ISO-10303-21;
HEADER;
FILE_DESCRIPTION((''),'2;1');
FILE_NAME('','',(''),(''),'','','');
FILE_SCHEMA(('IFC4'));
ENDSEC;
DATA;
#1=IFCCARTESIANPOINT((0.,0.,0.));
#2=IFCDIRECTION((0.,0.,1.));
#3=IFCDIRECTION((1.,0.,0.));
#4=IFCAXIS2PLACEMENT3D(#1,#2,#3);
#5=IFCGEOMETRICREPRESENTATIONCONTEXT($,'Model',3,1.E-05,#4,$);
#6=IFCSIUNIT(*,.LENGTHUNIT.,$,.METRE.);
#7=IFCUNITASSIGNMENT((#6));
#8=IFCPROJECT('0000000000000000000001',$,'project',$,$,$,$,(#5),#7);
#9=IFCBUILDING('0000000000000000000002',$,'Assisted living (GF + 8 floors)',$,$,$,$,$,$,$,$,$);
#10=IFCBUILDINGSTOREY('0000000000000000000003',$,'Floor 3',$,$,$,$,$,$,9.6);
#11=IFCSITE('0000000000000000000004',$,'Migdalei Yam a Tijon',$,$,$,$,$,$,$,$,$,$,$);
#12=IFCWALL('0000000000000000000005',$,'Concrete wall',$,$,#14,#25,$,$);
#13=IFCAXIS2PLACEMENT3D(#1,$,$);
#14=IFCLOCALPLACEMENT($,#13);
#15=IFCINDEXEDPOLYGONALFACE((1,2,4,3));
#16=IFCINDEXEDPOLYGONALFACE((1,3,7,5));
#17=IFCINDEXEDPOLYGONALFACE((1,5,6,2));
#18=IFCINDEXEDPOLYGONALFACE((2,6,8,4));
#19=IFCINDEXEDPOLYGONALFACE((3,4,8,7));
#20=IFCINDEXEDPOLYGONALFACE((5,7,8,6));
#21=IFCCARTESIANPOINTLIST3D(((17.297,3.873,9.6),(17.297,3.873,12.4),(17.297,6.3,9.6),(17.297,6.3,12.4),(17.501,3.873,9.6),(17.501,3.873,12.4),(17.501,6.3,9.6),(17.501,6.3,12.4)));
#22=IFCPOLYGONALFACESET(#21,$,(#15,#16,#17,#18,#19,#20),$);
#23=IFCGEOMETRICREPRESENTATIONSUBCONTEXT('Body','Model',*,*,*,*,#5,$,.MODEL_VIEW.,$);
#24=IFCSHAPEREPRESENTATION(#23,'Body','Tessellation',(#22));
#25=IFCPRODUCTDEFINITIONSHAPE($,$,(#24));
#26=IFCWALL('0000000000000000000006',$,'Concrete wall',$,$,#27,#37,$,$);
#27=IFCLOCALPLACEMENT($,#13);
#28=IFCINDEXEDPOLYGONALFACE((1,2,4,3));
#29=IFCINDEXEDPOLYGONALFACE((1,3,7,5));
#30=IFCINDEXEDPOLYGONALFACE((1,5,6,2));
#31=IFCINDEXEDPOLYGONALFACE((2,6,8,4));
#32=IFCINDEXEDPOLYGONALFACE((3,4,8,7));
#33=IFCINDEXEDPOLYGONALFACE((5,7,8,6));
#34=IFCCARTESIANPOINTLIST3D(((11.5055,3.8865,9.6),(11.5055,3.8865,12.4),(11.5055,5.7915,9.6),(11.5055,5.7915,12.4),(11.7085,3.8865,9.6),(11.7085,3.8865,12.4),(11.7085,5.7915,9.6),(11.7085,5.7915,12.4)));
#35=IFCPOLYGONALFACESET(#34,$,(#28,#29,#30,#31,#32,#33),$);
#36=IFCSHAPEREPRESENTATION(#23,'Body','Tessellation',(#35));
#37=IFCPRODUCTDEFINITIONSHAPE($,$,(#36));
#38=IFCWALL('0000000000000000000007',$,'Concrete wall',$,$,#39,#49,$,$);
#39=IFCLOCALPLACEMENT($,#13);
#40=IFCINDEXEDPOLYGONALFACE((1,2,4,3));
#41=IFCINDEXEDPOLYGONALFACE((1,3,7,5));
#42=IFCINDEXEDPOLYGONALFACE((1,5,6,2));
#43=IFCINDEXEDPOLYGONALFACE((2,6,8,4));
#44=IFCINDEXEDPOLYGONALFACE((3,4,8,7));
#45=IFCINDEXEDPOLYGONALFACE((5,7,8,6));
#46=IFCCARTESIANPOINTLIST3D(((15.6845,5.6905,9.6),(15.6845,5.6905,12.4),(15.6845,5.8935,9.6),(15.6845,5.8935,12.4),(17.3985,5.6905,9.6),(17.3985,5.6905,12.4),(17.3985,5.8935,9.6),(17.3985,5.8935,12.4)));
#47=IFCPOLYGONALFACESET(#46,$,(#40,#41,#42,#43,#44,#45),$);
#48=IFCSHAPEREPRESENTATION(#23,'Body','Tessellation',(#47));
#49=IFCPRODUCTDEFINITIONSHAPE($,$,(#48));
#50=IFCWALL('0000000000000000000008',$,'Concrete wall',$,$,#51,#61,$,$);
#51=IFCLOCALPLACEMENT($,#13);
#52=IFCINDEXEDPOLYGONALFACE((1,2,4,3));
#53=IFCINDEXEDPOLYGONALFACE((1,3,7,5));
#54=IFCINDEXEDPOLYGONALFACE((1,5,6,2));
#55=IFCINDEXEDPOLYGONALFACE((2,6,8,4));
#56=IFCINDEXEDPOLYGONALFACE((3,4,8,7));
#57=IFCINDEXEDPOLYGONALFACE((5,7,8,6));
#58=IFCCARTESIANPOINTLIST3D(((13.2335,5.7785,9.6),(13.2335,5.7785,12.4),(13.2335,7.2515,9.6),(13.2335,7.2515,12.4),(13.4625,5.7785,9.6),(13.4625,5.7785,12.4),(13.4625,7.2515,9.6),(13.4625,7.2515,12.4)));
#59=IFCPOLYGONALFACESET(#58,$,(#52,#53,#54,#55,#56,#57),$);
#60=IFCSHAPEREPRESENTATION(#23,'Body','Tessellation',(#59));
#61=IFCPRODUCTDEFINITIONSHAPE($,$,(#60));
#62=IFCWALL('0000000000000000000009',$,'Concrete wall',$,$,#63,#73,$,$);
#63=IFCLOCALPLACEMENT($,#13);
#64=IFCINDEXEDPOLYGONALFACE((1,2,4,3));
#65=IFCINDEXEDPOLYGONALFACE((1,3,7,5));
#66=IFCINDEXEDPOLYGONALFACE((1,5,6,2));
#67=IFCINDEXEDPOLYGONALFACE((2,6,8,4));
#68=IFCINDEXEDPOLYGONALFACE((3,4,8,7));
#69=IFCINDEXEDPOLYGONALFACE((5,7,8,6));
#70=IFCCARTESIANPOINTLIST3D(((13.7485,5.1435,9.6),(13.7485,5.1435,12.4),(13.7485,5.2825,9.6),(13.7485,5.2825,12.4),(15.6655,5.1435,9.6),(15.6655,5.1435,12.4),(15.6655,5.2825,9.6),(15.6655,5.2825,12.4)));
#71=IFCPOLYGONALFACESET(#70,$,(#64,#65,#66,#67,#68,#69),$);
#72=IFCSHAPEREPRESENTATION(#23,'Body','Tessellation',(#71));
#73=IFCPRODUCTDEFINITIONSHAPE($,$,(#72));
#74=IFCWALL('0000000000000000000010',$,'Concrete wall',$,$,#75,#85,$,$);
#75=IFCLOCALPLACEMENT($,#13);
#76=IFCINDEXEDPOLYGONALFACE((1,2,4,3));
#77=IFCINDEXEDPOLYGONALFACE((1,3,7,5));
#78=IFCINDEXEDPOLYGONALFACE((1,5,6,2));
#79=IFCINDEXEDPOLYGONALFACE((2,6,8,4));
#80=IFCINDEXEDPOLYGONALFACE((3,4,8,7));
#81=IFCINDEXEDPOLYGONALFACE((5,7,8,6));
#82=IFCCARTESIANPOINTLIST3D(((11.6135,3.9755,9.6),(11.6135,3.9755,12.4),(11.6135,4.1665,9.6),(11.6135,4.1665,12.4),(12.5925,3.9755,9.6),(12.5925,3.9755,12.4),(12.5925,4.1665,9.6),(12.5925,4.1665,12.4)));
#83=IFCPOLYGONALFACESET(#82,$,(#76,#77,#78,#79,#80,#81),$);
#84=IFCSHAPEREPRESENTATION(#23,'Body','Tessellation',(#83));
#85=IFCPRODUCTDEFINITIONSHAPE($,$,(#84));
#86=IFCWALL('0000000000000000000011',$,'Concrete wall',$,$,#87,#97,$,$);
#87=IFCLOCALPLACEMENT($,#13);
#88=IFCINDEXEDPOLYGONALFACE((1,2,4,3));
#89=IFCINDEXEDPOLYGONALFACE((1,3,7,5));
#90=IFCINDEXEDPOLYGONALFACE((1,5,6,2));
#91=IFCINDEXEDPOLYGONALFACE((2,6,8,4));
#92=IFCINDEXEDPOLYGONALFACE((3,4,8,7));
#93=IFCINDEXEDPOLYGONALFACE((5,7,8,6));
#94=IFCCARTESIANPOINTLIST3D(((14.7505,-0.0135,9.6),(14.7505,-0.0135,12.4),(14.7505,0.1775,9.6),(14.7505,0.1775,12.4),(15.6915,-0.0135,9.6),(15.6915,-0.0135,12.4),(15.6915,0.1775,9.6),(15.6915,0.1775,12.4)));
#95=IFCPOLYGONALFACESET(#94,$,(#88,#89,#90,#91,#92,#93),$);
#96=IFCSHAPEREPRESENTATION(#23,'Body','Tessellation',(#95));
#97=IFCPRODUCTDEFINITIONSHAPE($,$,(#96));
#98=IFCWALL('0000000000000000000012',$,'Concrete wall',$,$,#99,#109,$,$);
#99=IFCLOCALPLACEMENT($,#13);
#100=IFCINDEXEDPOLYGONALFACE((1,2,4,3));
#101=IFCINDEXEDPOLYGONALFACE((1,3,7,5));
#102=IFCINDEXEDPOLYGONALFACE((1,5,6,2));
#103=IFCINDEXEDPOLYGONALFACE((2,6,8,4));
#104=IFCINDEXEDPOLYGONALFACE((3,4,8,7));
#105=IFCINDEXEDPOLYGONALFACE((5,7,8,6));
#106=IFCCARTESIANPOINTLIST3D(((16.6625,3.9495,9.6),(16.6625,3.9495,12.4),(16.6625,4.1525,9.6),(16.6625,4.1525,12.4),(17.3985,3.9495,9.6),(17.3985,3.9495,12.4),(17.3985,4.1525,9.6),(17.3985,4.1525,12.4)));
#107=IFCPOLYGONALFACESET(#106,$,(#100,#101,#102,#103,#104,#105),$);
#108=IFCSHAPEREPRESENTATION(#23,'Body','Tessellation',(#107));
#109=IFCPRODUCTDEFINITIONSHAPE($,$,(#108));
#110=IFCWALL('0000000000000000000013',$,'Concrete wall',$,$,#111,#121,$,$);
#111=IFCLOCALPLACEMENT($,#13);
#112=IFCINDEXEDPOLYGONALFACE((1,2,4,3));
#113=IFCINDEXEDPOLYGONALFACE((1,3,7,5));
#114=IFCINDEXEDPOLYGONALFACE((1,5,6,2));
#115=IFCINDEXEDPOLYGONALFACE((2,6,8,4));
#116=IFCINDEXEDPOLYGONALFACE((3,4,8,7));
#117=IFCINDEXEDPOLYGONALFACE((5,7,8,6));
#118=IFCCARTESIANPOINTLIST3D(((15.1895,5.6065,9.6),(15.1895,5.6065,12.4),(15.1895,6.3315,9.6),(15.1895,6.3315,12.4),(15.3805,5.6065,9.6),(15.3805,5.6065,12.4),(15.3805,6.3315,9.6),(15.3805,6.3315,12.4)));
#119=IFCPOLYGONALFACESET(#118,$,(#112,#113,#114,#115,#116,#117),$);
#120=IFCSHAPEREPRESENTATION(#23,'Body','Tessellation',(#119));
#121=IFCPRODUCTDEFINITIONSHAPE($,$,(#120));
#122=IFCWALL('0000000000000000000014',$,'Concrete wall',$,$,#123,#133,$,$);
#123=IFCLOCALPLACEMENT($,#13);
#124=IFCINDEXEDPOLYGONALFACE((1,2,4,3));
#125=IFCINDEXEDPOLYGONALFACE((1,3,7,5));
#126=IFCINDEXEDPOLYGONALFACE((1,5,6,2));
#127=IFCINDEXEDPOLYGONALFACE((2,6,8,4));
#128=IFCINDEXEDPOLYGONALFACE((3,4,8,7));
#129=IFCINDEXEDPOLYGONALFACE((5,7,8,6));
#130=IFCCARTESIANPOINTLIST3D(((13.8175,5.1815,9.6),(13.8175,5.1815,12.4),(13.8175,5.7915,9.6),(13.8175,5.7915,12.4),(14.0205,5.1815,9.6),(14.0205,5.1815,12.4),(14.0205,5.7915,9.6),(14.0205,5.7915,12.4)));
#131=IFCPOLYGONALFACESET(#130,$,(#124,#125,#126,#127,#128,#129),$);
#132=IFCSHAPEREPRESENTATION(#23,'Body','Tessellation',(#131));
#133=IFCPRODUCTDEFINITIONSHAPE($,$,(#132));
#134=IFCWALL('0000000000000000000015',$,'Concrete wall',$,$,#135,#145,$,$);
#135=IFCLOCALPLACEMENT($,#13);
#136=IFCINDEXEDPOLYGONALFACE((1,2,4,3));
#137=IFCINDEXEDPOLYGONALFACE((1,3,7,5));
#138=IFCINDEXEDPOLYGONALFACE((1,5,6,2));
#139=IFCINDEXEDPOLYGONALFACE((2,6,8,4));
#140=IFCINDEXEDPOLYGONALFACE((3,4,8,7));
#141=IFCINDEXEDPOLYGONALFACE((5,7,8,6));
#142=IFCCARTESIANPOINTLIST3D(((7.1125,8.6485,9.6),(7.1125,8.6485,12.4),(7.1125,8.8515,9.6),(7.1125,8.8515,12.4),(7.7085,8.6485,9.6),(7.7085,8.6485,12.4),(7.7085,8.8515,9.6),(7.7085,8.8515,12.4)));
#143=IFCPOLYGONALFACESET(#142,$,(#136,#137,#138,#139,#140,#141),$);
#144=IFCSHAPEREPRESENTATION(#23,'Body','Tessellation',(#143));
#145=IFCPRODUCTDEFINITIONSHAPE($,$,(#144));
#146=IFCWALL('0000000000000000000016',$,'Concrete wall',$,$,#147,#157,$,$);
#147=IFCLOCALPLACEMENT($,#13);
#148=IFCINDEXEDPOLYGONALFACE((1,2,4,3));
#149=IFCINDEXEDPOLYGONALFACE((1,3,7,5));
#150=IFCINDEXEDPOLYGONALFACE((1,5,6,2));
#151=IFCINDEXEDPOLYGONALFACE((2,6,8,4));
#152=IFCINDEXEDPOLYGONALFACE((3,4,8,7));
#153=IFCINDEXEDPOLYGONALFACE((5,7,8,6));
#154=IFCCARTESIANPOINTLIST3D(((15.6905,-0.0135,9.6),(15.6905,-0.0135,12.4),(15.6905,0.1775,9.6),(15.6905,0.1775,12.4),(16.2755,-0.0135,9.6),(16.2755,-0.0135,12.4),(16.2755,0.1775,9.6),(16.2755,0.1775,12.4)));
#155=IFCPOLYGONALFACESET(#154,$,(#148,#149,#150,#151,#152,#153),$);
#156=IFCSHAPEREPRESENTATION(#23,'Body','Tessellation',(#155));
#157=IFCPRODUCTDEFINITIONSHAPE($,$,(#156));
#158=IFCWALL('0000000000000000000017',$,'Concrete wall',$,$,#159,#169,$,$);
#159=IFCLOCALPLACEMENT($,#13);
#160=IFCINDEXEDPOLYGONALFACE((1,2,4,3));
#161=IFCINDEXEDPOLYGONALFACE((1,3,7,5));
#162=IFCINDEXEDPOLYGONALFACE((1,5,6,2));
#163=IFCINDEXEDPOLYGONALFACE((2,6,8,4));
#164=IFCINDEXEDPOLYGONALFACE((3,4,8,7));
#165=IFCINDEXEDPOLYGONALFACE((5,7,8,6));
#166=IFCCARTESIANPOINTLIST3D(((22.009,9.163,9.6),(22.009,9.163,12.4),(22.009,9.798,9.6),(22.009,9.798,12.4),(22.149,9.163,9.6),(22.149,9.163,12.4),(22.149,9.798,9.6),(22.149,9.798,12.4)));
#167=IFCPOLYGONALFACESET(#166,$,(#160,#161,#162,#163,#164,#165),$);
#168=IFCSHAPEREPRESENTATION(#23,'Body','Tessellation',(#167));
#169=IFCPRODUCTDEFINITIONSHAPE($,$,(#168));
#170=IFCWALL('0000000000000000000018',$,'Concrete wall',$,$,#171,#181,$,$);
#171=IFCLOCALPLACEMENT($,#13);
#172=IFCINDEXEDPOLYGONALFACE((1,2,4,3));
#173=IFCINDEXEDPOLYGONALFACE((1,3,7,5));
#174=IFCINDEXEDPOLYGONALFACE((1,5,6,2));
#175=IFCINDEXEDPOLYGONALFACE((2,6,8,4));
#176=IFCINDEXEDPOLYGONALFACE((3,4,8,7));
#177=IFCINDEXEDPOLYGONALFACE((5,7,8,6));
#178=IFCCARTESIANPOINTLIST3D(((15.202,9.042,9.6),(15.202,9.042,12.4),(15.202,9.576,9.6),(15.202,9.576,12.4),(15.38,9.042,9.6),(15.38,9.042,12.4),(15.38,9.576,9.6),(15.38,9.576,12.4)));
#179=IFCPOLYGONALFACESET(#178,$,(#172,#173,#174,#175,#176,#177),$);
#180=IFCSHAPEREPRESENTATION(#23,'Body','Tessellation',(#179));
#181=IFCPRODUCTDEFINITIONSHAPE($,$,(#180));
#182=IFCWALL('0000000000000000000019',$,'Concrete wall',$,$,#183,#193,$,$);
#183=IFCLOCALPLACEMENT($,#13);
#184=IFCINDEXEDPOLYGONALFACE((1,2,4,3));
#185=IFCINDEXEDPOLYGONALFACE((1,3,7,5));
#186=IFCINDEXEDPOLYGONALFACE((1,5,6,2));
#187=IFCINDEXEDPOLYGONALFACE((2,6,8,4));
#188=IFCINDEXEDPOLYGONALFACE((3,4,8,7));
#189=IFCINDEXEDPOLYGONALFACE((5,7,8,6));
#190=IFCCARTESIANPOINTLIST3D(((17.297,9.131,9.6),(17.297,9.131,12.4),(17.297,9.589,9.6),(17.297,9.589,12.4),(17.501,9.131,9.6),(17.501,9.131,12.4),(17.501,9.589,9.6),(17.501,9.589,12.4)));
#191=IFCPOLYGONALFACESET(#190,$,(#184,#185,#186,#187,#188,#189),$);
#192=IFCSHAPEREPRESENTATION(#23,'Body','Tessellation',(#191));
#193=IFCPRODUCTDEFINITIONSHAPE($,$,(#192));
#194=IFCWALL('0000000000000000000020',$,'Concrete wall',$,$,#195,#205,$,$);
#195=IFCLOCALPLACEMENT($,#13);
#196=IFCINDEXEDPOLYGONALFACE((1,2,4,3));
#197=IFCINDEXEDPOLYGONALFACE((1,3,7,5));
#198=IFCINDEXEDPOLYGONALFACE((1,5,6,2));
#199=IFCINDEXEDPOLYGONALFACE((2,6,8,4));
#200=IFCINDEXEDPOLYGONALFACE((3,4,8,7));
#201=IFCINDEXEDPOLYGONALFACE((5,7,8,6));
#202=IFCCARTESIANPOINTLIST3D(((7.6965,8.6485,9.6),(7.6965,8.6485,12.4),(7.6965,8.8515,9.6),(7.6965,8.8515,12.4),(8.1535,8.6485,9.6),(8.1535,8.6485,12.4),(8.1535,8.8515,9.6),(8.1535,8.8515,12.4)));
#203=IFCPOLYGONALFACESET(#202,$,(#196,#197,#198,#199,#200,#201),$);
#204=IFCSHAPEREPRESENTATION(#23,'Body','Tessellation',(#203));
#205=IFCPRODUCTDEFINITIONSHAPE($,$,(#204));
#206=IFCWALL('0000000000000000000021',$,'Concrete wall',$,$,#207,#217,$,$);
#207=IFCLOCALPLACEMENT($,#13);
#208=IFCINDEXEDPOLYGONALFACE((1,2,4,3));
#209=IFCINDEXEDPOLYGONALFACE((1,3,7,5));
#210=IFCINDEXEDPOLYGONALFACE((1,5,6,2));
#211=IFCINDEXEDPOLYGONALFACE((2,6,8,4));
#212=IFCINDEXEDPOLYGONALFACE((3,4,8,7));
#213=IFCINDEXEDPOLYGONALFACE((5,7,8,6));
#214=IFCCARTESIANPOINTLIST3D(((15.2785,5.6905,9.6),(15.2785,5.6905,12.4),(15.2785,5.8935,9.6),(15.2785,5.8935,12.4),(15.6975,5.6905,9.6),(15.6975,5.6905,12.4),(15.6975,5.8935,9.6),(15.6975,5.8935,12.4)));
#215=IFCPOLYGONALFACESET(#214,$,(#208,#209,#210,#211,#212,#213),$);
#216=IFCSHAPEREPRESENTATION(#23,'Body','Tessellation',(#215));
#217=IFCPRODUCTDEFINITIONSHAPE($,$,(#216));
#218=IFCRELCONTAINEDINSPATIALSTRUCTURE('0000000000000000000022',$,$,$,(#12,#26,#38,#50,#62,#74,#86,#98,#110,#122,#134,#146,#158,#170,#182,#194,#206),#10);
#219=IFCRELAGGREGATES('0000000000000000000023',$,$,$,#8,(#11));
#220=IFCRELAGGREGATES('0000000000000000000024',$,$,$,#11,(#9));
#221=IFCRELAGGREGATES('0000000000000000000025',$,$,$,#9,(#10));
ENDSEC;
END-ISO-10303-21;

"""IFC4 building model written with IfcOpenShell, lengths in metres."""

from ifc_helpers import new_model, si_unit, frame, origin_with_axes, context, subcontext, project, spatial, line, indexed_curve, outline, extrude, element, save


model = new_model("IFC4")

# Units and contexts
model_context = context("Model", 3, precision=1e-05, world=origin_with_axes())
body_context = subcontext(model_context, "Body", "Model", "MODEL_VIEW")
ifc_project = project(units=[si_unit("LENGTHUNIT", "METRE")], contexts=[model_context])

# Site, building, storey
site = spatial("IfcSite", under=ifc_project, Name="Migdalei Yam a Tijon")
building = spatial("IfcBuilding", under=site, Name="Assisted living (GF + 8 floors)")
storey = spatial("IfcBuildingStorey", under=building, Name="Floor 3", Elevation=9.6)

# Walls
element("IfcWall", 1, inside=storey, Name="Concrete wall", context=body_context, shape_type="SweptSolid", body=[
    extrude(outline(indexed_curve([(0.0, 0.0), (0.204, 0.0), (0.204, 2.427), (0.0, 2.427)], segments=[line(1, 2, 3, 4, 1)])), frame((17.297, 3.873, 9.6), z_axis=(0.0, 0.0, 1.0), x_axis=(1.0, 0.0, 0.0)), (0.0, 0.0, 1.0), 2.8),
])
element("IfcWall", 2, inside=storey, Name="Concrete wall", context=body_context, shape_type="SweptSolid", body=[
    extrude(outline(indexed_curve([(0.0, 0.0), (0.203, 0.0), (0.203, 1.905), (0.0, 1.905)], segments=[line(1, 2, 3, 4, 1)])), frame((11.5055, 3.8865, 9.6), z_axis=(0.0, 0.0, 1.0), x_axis=(1.0, 0.0, 0.0)), (0.0, 0.0, 1.0), 2.8),
])
element("IfcWall", 3, inside=storey, Name="Concrete wall", context=body_context, shape_type="SweptSolid", body=[
    extrude(outline(indexed_curve([(0.0, 0.0), (1.714, 0.0), (1.714, 0.203), (0.0, 0.203)], segments=[line(1, 2, 3, 4, 1)])), frame((15.6845, 5.6905, 9.6), z_axis=(0.0, 0.0, 1.0), x_axis=(1.0, 0.0, 0.0)), (0.0, 0.0, 1.0), 2.8),
])
element("IfcWall", 4, inside=storey, Name="Concrete wall", context=body_context, shape_type="SweptSolid", body=[
    extrude(outline(indexed_curve([(0.0, 0.0), (0.229, 0.0), (0.229, 1.473), (0.0, 1.473)], segments=[line(1, 2, 3, 4, 1)])), frame((13.2335, 5.7785, 9.6), z_axis=(0.0, 0.0, 1.0), x_axis=(1.0, 0.0, 0.0)), (0.0, 0.0, 1.0), 2.8),
])
element("IfcWall", 5, inside=storey, Name="Concrete wall", context=body_context, shape_type="SweptSolid", body=[
    extrude(outline(indexed_curve([(0.0, 0.0), (1.917, 0.0), (1.917, 0.139), (0.0, 0.139)], segments=[line(1, 2, 3, 4, 1)])), frame((13.7485, 5.1435, 9.6), z_axis=(0.0, 0.0, 1.0), x_axis=(1.0, 0.0, 0.0)), (0.0, 0.0, 1.0), 2.8),
])
element("IfcWall", 6, inside=storey, Name="Concrete wall", context=body_context, shape_type="SweptSolid", body=[
    extrude(outline(indexed_curve([(0.0, 0.0), (0.979, 0.0), (0.979, 0.191), (0.0, 0.191)], segments=[line(1, 2, 3, 4, 1)])), frame((11.6135, 3.9755, 9.6), z_axis=(0.0, 0.0, 1.0), x_axis=(1.0, 0.0, 0.0)), (0.0, 0.0, 1.0), 2.8),
])
element("IfcWall", 7, inside=storey, Name="Concrete wall", context=body_context, shape_type="SweptSolid", body=[
    extrude(outline(indexed_curve([(0.0, 0.0), (0.941, 0.0), (0.941, 0.191), (0.0, 0.191)], segments=[line(1, 2, 3, 4, 1)])), frame((14.7505, -0.0135, 9.6), z_axis=(0.0, 0.0, 1.0), x_axis=(1.0, 0.0, 0.0)), (0.0, 0.0, 1.0), 2.8),
])
element("IfcWall", 8, inside=storey, Name="Concrete wall", context=body_context, shape_type="SweptSolid", body=[
    extrude(outline(indexed_curve([(0.0, 0.0), (0.736, 0.0), (0.736, 0.203), (0.0, 0.203)], segments=[line(1, 2, 3, 4, 1)])), frame((16.6625, 3.9495, 9.6), z_axis=(0.0, 0.0, 1.0), x_axis=(1.0, 0.0, 0.0)), (0.0, 0.0, 1.0), 2.8),
])
element("IfcWall", 9, inside=storey, Name="Concrete wall", context=body_context, shape_type="SweptSolid", body=[
    extrude(outline(indexed_curve([(0.0, 0.0), (0.191, 0.0), (0.191, 0.725), (0.0, 0.725)], segments=[line(1, 2, 3, 4, 1)])), frame((15.1895, 5.6065, 9.6), z_axis=(0.0, 0.0, 1.0), x_axis=(1.0, 0.0, 0.0)), (0.0, 0.0, 1.0), 2.8),
])
element("IfcWall", 10, inside=storey, Name="Concrete wall", context=body_context, shape_type="SweptSolid", body=[
    extrude(outline(indexed_curve([(0.0, 0.0), (0.203, 0.0), (0.203, 0.61), (0.0, 0.61)], segments=[line(1, 2, 3, 4, 1)])), frame((13.8175, 5.1815, 9.6), z_axis=(0.0, 0.0, 1.0), x_axis=(1.0, 0.0, 0.0)), (0.0, 0.0, 1.0), 2.8),
])
element("IfcWall", 11, inside=storey, Name="Concrete wall", context=body_context, shape_type="SweptSolid", body=[
    extrude(outline(indexed_curve([(0.0, 0.0), (0.596, 0.0), (0.596, 0.203), (0.0, 0.203)], segments=[line(1, 2, 3, 4, 1)])), frame((7.1125, 8.6485, 9.6), z_axis=(0.0, 0.0, 1.0), x_axis=(1.0, 0.0, 0.0)), (0.0, 0.0, 1.0), 2.8),
])
element("IfcWall", 12, inside=storey, Name="Concrete wall", context=body_context, shape_type="SweptSolid", body=[
    extrude(outline(indexed_curve([(0.0, 0.0), (0.585, 0.0), (0.585, 0.191), (0.0, 0.191)], segments=[line(1, 2, 3, 4, 1)])), frame((15.6905, -0.0135, 9.6), z_axis=(0.0, 0.0, 1.0), x_axis=(1.0, 0.0, 0.0)), (0.0, 0.0, 1.0), 2.8),
])
element("IfcWall", 13, inside=storey, Name="Concrete wall", context=body_context, shape_type="SweptSolid", body=[
    extrude(outline(indexed_curve([(0.0, 0.0), (0.14, 0.0), (0.14, 0.635), (0.0, 0.635)], segments=[line(1, 2, 3, 4, 1)])), frame((22.009, 9.163, 9.6), z_axis=(0.0, 0.0, 1.0), x_axis=(1.0, 0.0, 0.0)), (0.0, 0.0, 1.0), 2.8),
])
element("IfcWall", 14, inside=storey, Name="Concrete wall", context=body_context, shape_type="SweptSolid", body=[
    extrude(outline(indexed_curve([(0.0, 0.0), (0.178, 0.0), (0.178, 0.534), (0.0, 0.534)], segments=[line(1, 2, 3, 4, 1)])), frame((15.202, 9.042, 9.6), z_axis=(0.0, 0.0, 1.0), x_axis=(1.0, 0.0, 0.0)), (0.0, 0.0, 1.0), 2.8),
])
element("IfcWall", 15, inside=storey, Name="Concrete wall", context=body_context, shape_type="SweptSolid", body=[
    extrude(outline(indexed_curve([(0.0, 0.0), (0.204, 0.0), (0.204, 0.458), (0.0, 0.458)], segments=[line(1, 2, 3, 4, 1)])), frame((17.297, 9.131, 9.6), z_axis=(0.0, 0.0, 1.0), x_axis=(1.0, 0.0, 0.0)), (0.0, 0.0, 1.0), 2.8),
])
element("IfcWall", 16, inside=storey, Name="Concrete wall", context=body_context, shape_type="SweptSolid", body=[
    extrude(outline(indexed_curve([(0.0, 0.0), (0.457, 0.0), (0.457, 0.203), (0.0, 0.203)], segments=[line(1, 2, 3, 4, 1)])), frame((7.6965, 8.6485, 9.6), z_axis=(0.0, 0.0, 1.0), x_axis=(1.0, 0.0, 0.0)), (0.0, 0.0, 1.0), 2.8),
])
element("IfcWall", 17, inside=storey, Name="Concrete wall", context=body_context, shape_type="SweptSolid", body=[
    extrude(outline(indexed_curve([(0.0, 0.0), (0.419, 0.0), (0.419, 0.203), (0.0, 0.203)], segments=[line(1, 2, 3, 4, 1)])), frame((15.2785, 5.6905, 9.6), z_axis=(0.0, 0.0, 1.0), x_axis=(1.0, 0.0, 0.0)), (0.0, 0.0, 1.0), 2.8),
])

save(model, "model.ifc")
